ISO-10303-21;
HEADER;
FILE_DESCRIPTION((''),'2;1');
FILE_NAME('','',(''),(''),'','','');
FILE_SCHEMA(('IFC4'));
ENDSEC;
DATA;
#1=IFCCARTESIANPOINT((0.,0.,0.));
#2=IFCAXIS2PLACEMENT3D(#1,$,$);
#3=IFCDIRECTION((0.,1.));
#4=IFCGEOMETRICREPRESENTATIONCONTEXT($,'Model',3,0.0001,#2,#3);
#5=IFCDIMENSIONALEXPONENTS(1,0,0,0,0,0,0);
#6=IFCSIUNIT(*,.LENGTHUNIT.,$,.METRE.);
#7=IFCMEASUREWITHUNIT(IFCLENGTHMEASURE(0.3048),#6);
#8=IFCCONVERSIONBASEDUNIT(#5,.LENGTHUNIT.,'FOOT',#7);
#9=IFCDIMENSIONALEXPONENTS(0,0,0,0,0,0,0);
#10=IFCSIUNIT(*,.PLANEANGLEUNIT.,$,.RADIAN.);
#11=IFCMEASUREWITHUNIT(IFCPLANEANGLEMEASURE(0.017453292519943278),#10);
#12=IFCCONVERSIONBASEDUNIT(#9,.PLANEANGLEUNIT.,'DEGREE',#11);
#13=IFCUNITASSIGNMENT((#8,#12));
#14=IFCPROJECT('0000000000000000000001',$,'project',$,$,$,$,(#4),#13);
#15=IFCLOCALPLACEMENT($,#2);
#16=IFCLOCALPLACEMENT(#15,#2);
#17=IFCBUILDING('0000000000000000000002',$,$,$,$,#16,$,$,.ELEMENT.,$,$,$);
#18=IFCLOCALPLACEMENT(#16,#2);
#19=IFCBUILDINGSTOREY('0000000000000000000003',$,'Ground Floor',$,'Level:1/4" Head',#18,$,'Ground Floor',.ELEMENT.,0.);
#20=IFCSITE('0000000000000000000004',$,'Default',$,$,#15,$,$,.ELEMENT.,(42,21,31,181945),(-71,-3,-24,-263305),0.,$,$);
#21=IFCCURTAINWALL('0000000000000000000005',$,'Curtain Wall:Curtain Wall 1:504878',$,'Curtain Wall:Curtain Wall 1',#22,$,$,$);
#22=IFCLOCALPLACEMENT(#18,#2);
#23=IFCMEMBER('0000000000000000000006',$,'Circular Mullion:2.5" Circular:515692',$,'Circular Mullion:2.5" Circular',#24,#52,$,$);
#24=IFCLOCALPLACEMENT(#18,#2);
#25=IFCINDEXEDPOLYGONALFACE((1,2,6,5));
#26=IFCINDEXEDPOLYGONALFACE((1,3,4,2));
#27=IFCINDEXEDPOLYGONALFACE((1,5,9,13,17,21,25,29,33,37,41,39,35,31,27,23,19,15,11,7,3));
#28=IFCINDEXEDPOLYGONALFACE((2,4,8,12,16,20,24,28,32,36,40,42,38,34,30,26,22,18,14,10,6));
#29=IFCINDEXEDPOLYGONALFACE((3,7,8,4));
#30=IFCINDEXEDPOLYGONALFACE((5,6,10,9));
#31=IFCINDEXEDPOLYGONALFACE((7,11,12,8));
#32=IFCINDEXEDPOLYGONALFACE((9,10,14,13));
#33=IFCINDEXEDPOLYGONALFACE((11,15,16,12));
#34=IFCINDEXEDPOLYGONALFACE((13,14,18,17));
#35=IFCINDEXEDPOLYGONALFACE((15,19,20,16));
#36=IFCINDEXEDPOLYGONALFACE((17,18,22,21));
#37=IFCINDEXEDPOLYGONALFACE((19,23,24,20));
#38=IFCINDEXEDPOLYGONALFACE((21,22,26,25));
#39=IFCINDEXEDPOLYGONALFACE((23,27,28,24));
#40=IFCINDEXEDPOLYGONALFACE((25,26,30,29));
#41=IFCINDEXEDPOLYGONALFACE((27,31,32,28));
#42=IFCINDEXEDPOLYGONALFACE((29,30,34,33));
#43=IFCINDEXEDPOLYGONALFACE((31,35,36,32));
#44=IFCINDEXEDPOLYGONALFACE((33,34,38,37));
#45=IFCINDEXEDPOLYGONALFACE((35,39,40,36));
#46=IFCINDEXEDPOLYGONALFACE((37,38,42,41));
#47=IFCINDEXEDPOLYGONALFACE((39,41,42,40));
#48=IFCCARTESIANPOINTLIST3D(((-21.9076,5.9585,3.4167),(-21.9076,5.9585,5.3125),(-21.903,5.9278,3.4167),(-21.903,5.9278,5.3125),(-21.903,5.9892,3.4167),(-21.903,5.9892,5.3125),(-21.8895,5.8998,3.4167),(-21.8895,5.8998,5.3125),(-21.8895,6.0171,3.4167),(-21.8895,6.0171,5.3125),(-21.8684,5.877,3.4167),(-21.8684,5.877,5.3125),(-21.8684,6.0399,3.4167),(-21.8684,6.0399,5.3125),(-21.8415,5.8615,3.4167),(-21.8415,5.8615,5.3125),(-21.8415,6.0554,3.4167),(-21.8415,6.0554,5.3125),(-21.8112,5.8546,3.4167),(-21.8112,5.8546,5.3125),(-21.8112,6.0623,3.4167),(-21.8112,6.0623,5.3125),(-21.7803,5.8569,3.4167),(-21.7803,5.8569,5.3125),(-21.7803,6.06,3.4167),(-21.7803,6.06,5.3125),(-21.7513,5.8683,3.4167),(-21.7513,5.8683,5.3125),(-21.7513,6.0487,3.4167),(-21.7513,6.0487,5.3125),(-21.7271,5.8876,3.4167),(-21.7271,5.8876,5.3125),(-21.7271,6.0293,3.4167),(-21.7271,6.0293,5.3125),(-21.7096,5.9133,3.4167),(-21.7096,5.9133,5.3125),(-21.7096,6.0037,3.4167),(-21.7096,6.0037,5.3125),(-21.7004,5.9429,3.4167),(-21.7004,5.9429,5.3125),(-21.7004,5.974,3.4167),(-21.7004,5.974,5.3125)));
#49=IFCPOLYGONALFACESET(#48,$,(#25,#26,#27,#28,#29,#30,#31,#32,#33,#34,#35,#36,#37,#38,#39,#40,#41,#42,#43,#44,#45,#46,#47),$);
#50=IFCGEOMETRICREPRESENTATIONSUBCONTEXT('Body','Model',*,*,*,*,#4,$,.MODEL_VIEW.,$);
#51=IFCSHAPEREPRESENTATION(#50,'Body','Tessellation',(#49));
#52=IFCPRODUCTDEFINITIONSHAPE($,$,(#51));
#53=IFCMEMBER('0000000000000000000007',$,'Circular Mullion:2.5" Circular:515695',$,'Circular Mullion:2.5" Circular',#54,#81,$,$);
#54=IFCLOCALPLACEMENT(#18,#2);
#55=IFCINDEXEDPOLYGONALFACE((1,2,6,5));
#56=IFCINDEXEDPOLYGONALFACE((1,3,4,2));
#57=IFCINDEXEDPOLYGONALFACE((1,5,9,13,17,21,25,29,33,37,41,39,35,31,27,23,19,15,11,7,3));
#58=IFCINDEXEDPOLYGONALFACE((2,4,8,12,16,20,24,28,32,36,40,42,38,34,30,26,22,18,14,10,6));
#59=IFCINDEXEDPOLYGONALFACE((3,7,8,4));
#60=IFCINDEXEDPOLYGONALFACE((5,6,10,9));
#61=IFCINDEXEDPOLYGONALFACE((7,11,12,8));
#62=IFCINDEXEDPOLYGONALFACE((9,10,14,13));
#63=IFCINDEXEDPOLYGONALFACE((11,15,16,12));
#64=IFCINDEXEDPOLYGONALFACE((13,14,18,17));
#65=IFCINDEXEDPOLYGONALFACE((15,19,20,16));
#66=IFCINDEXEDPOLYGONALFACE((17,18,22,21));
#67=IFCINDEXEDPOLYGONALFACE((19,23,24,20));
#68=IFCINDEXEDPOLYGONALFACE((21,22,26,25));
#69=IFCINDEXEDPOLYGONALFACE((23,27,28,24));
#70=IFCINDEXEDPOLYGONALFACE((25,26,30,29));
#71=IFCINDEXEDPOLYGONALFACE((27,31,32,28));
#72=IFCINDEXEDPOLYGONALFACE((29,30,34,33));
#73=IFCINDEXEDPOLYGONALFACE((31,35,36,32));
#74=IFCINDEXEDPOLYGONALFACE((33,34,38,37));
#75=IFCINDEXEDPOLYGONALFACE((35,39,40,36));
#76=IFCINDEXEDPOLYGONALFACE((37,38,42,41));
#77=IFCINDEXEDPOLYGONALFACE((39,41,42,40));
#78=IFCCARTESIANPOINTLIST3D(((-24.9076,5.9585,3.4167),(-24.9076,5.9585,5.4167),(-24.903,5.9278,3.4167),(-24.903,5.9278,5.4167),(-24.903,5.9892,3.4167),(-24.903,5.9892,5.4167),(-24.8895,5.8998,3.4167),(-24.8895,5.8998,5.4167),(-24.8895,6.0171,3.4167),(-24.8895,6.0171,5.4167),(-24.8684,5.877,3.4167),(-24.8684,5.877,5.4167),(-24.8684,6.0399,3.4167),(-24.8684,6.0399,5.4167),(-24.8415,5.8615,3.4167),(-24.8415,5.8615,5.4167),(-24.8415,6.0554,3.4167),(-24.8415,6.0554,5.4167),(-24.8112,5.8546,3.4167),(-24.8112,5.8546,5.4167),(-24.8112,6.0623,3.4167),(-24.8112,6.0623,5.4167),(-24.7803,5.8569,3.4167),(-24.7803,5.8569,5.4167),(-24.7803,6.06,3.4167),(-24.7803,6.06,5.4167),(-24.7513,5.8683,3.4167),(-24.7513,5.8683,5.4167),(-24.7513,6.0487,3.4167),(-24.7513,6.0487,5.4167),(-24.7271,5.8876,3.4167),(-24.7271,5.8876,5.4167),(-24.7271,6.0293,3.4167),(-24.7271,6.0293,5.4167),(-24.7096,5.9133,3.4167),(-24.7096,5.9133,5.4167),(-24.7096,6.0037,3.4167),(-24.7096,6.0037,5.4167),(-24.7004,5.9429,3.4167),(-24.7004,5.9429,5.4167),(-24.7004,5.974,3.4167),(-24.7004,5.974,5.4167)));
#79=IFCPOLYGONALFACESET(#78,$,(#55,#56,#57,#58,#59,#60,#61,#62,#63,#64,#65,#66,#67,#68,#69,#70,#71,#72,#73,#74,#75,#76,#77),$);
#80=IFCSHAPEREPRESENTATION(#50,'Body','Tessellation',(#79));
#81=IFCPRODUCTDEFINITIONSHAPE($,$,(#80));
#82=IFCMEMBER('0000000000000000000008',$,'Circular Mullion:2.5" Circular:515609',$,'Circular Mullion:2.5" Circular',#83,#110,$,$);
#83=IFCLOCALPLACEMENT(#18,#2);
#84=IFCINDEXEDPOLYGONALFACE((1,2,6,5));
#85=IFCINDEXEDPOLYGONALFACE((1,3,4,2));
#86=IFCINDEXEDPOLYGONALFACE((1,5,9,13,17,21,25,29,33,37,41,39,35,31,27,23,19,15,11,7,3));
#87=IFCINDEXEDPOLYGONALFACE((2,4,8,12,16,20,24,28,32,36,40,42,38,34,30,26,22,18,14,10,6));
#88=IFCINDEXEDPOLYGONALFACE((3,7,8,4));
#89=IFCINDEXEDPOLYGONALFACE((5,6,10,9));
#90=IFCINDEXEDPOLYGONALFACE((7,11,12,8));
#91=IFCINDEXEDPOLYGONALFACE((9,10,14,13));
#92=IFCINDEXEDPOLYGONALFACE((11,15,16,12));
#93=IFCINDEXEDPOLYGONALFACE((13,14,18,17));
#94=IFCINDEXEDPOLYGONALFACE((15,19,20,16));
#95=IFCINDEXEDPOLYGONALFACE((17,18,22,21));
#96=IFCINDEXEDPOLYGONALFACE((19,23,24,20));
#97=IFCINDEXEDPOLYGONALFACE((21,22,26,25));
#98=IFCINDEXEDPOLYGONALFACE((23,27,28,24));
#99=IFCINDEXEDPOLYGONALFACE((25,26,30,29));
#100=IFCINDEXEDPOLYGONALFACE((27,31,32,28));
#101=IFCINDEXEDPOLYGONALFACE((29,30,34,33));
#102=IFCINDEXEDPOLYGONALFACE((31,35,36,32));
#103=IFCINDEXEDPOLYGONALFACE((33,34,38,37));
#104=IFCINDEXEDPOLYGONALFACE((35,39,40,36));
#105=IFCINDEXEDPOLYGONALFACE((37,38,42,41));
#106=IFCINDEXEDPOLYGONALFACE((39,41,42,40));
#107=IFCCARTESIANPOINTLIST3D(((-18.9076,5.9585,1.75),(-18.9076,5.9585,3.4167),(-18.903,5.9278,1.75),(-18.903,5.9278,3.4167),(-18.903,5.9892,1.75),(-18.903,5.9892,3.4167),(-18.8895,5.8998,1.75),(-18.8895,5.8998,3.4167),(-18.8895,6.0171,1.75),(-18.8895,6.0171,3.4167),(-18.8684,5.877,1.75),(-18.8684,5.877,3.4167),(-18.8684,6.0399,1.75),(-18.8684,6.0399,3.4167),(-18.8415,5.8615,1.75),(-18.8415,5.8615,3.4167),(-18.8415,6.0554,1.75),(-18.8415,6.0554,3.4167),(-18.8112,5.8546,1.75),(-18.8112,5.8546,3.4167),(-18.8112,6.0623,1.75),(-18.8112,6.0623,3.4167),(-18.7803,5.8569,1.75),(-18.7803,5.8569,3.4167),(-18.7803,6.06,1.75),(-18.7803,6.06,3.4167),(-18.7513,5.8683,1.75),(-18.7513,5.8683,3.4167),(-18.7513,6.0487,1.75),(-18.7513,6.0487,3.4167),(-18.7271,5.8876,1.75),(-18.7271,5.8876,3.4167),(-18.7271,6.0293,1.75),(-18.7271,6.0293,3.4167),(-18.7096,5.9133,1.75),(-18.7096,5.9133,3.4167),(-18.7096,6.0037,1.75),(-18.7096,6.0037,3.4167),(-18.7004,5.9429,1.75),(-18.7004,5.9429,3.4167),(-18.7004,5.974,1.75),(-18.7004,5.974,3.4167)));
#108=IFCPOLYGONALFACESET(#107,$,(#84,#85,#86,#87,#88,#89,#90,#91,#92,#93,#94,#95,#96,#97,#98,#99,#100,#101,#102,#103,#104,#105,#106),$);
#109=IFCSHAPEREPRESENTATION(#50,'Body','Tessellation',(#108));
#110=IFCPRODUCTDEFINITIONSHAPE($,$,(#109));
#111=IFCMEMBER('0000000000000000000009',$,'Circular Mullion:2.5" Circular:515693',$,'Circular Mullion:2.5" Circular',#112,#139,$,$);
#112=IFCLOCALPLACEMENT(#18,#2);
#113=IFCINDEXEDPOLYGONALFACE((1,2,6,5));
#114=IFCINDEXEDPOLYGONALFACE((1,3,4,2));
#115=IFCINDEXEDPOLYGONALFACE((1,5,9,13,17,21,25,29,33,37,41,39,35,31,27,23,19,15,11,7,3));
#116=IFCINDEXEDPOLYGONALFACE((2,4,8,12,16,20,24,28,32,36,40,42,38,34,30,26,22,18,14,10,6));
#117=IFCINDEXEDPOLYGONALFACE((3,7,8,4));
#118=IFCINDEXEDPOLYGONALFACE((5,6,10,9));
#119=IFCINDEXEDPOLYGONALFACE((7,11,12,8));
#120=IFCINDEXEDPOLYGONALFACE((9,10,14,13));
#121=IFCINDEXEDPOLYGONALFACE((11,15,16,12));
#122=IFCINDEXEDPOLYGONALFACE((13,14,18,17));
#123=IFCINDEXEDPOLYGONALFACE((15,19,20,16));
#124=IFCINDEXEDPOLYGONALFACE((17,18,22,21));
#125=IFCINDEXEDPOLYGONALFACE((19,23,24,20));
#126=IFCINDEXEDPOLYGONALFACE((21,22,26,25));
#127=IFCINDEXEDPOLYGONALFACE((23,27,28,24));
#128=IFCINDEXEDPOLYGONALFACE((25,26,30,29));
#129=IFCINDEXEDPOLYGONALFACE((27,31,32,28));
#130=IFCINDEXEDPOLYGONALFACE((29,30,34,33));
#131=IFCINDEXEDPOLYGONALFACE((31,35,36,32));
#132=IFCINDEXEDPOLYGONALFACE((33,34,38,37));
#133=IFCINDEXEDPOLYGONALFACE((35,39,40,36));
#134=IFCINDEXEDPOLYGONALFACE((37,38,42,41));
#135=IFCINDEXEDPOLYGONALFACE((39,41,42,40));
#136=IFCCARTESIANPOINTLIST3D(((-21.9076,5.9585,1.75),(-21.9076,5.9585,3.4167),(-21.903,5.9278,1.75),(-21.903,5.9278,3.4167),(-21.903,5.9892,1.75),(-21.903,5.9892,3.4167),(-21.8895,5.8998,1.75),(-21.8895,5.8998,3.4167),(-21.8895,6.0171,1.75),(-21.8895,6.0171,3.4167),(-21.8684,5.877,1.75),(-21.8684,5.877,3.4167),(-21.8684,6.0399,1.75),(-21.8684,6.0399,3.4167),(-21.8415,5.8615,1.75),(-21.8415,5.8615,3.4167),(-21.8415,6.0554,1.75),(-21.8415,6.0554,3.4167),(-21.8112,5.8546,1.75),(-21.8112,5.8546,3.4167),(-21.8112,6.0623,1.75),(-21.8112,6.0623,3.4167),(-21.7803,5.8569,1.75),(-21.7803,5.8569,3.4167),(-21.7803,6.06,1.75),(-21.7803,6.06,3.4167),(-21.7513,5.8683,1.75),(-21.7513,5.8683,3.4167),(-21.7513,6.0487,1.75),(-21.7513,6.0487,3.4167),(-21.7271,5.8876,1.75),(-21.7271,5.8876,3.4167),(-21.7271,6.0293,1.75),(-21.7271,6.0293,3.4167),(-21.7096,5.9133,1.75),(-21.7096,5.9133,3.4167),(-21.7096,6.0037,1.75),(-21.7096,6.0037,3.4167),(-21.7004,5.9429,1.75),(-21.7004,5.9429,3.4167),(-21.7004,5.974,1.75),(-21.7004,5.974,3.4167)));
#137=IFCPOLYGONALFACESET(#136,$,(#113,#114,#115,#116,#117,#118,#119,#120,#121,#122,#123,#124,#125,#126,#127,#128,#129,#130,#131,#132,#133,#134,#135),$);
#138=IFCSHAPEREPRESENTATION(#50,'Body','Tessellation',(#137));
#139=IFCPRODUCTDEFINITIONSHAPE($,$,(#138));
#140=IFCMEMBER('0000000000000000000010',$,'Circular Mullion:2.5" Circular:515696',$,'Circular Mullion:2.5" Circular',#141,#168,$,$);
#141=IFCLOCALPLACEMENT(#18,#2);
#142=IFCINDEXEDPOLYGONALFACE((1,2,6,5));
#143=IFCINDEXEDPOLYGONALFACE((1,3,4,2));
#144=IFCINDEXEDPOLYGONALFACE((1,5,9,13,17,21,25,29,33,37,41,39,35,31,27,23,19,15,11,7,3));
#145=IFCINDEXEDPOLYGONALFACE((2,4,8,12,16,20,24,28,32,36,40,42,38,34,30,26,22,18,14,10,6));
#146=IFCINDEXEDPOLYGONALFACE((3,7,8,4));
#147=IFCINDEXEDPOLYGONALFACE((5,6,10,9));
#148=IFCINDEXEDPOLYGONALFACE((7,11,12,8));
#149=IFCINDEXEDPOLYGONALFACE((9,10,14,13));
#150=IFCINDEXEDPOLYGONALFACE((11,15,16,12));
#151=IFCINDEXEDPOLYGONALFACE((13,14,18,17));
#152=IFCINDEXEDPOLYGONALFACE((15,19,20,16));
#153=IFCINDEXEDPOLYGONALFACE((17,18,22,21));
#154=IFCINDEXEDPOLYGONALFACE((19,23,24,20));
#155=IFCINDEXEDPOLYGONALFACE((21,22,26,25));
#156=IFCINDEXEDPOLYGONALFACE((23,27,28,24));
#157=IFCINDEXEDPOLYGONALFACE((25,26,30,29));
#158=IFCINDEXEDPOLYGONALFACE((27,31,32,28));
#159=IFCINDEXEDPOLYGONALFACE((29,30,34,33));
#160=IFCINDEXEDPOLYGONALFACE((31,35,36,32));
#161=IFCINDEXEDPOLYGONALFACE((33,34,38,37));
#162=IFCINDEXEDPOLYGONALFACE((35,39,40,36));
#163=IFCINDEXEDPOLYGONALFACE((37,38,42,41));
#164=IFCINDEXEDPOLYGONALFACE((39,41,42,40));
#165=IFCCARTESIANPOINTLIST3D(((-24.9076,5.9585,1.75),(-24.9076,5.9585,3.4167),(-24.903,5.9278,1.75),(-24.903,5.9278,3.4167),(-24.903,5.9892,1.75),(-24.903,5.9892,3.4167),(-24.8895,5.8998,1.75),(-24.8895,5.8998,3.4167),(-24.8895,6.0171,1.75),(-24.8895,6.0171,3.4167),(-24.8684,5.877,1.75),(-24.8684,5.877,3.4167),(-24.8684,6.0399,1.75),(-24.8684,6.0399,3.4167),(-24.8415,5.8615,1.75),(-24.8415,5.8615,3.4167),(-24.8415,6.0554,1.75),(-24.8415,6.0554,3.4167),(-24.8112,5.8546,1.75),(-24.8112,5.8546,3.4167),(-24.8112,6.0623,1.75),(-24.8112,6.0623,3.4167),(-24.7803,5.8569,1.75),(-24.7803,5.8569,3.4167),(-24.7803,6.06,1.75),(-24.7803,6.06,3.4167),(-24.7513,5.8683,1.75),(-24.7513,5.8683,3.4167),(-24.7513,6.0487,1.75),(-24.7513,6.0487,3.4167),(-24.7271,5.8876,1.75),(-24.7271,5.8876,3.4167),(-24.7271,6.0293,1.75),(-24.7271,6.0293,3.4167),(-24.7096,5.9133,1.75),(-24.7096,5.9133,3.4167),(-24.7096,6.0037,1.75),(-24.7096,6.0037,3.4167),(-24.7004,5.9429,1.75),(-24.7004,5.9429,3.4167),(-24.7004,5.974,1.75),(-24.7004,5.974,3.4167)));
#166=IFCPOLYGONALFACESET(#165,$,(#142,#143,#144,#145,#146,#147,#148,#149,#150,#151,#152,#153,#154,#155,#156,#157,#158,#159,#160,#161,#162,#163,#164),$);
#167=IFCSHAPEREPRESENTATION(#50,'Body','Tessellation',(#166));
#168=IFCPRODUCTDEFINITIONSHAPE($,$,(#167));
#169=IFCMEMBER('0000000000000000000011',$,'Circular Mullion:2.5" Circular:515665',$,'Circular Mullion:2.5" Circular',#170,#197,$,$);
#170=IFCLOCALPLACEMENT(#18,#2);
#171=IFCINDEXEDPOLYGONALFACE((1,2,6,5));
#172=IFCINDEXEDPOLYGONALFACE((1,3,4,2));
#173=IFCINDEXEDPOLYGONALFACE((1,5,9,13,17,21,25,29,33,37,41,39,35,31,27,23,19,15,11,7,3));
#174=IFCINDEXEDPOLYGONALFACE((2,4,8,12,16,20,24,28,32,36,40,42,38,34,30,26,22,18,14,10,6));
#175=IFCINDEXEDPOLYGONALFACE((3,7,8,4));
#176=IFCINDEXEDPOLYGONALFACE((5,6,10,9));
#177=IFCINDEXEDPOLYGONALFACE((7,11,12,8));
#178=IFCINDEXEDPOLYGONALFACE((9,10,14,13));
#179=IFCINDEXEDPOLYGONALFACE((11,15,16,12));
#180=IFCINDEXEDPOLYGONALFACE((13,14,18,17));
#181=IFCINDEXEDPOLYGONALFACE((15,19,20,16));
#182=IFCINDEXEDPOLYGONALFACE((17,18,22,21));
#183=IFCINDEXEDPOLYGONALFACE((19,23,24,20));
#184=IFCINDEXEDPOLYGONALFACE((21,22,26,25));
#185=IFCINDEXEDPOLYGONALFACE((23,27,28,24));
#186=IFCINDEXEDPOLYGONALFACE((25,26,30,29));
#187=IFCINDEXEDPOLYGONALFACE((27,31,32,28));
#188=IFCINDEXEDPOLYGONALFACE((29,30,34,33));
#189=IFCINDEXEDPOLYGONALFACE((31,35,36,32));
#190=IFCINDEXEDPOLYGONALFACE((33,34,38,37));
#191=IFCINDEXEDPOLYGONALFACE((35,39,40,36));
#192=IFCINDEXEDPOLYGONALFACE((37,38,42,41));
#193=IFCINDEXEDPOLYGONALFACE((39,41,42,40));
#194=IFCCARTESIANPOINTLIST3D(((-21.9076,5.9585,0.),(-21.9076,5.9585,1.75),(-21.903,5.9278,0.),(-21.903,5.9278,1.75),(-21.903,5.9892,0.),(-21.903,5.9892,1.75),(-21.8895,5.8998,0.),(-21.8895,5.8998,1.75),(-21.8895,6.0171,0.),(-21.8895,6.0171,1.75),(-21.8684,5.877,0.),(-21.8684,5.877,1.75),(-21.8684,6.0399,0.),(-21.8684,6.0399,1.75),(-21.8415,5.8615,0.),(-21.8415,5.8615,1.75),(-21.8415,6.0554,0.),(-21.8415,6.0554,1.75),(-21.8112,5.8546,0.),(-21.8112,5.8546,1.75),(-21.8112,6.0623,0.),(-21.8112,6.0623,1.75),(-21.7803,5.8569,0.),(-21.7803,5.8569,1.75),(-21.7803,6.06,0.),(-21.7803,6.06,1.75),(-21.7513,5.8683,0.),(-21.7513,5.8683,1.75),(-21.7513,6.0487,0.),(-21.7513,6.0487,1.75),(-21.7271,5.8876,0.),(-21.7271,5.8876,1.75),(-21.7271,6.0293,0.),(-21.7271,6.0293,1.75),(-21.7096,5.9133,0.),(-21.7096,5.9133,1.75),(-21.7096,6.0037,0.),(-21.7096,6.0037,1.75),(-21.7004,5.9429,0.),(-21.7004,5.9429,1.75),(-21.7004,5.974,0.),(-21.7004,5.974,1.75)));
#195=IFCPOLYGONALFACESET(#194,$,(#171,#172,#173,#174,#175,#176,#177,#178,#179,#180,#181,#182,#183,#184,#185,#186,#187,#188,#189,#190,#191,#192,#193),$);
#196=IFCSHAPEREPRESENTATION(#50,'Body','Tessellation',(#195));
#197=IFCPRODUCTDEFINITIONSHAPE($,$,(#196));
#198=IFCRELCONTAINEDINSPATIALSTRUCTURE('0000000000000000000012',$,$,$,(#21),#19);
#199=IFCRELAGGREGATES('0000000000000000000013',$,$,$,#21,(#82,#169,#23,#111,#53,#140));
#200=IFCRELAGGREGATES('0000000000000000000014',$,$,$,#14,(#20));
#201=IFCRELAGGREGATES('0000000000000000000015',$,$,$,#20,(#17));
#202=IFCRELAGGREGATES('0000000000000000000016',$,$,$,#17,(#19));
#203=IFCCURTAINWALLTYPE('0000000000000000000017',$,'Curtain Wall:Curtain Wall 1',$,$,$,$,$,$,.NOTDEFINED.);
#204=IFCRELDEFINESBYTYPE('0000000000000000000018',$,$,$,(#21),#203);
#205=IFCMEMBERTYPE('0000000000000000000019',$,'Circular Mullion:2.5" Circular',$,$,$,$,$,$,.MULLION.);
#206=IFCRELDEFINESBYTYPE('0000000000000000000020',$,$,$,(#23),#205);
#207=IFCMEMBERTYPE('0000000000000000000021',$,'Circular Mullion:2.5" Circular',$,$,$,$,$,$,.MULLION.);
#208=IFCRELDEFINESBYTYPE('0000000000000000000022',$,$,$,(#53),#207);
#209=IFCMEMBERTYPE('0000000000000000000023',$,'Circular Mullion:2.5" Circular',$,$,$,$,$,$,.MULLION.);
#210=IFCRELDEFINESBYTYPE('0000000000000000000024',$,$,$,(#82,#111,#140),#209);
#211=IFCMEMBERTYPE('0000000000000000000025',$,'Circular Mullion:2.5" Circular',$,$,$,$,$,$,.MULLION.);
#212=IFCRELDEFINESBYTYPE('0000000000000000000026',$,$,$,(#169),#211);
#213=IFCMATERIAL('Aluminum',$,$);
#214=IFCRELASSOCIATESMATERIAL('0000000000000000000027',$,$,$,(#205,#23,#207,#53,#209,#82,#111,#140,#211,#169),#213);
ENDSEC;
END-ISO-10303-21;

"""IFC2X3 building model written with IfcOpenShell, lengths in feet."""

from ifc_helpers import new_model, entity, si_unit, converted_unit, direction, frame, frame_2d, origin, place, context, subcontext, project, spatial, circle, extrude, source, transform, mapped, material, type_object, type_shapes, element, aggregate, save


model = new_model("IFC2X3")

# Units and contexts
model_context = context("Model", 3, precision=0.0001, world=origin(), true_north=direction((0.0, 1.0)))
body_context = subcontext(model_context, "Body", "Model", "MODEL_VIEW")
ifc_project = project(units=[converted_unit("LENGTHUNIT", "FOOT", entity("IfcLengthMeasure", 0.3048), si_unit("LENGTHUNIT", "METRE"), dimensions=[1, 0, 0, 0, 0, 0, 0]), converted_unit("PLANEANGLEUNIT", "DEGREE", entity("IfcPlaneAngleMeasure", 0.017453292519943278), si_unit("PLANEANGLEUNIT", "RADIAN"), dimensions=[0, 0, 0, 0, 0, 0, 0])], contexts=[model_context])

# Site, building, storey
site_placement = place(None, origin())
site = spatial("IfcSite", under=ifc_project, at=site_placement, Name="Default", CompositionType="ELEMENT", RefLatitude=(42, 21, 31, 181945), RefLongitude=(-71, -3, -24, -263305), RefElevation=0.0)
building_placement = place(site_placement, origin())
building = spatial("IfcBuilding", under=site, at=building_placement, CompositionType="ELEMENT")
storey_placement = place(building_placement, origin())
storey = spatial("IfcBuildingStorey", under=building, at=storey_placement, Name="Ground Floor", ObjectType="Level:1/4\" Head", LongName="Ground Floor", CompositionType="ELEMENT", Elevation=0.0)

# Curtain wall, members
curtain_wall_type = type_object("IfcCurtainWallType", Name="Curtain Wall:Curtain Wall 1", PredefinedType="NOTDEFINED")
curtain_wall_placement = place(storey_placement, origin())
curtain_wall = element("IfcCurtainWall", 1, at=curtain_wall_placement, inside=storey, type_object=curtain_wall_type, Name="Curtain Wall:Curtain Wall 1:504878", ObjectType="Curtain Wall:Curtain Wall 1")
ifc_material_1 = material(Name="Aluminum")
member_type_1 = type_object("IfcMemberType", Name="Circular Mullion:2.5\" Circular", PredefinedType="MULLION", material=ifc_material_1)
shared_shape_1 = source(origin(), body_context, "Body", "SweptSolid", [
    extrude(circle(Radius=0.1042, at=frame_2d((0.0, 0.0), x_axis=(1.0, 0.0))), frame((0.0, 0.0, -1.8958)), (0.0, 0.0, 1.0), 1.8958),
])
type_shapes(member_type_1, [shared_shape_1])
member_1_placement = place(curtain_wall_placement, frame((-21.8034, 5.9585, 3.4167), z_axis=(0.0, 0.0, -1.0), x_axis=(-1.0, 0.0, 0.0)))
member_1 = element("IfcMember", 2, at=member_1_placement, type_object=member_type_1, material=ifc_material_1, Name="Circular Mullion:2.5\" Circular:515692", ObjectType="Circular Mullion:2.5\" Circular", context=body_context, shape_type="MappedRepresentation", body=[
    mapped(shared_shape_1, transform((0.0, 0.0, 0.0), scale=1.0)),
])
member_type_2 = type_object("IfcMemberType", Name="Circular Mullion:2.5\" Circular", PredefinedType="MULLION", material=ifc_material_1)
shared_shape_2 = source(origin(), body_context, "Body", "SweptSolid", [
    extrude(circle(Radius=0.1042, at=frame_2d((0.0, 0.0), x_axis=(1.0, 0.0))), frame((0.0, 0.0, -2.0)), (0.0, 0.0, 1.0), 2.0),
])
type_shapes(member_type_2, [shared_shape_2])
member_2_placement = place(curtain_wall_placement, frame((-24.8034, 5.9585, 3.4167), z_axis=(0.0, 0.0, -1.0), x_axis=(-1.0, 0.0, 0.0)))
member_2 = element("IfcMember", 3, at=member_2_placement, type_object=member_type_2, material=ifc_material_1, Name="Circular Mullion:2.5\" Circular:515695", ObjectType="Circular Mullion:2.5\" Circular", context=body_context, shape_type="MappedRepresentation", body=[
    mapped(shared_shape_2, transform((0.0, 0.0, 0.0), scale=1.0)),
])
member_type_3 = type_object("IfcMemberType", Name="Circular Mullion:2.5\" Circular", PredefinedType="MULLION", material=ifc_material_1)
shared_shape_3 = source(origin(), body_context, "Body", "SweptSolid", [
    extrude(circle(Radius=0.1042, at=frame_2d((0.0, 0.0), x_axis=(1.0, 0.0))), frame((0.0, 0.0, -1.6667)), (0.0, 0.0, 1.0), 1.6667),
])
type_shapes(member_type_3, [shared_shape_3])
member_3_placement = place(curtain_wall_placement, frame((-18.8034, 5.9585, 1.75), z_axis=(0.0, 0.0, -1.0), x_axis=(-1.0, 0.0, 0.0)))
member_3 = element("IfcMember", 4, at=member_3_placement, type_object=member_type_3, material=ifc_material_1, Name="Circular Mullion:2.5\" Circular:515609", ObjectType="Circular Mullion:2.5\" Circular", context=body_context, shape_type="MappedRepresentation", body=[
    mapped(shared_shape_3, transform((0.0, 0.0, 0.0), scale=1.0)),
])
member_4_placement = place(curtain_wall_placement, frame((-21.8034, 5.9585, 1.75), z_axis=(0.0, 0.0, -1.0), x_axis=(-1.0, 0.0, 0.0)))
member_4 = element("IfcMember", 5, at=member_4_placement, type_object=member_type_3, material=ifc_material_1, Name="Circular Mullion:2.5\" Circular:515693", ObjectType="Circular Mullion:2.5\" Circular", context=body_context, shape_type="MappedRepresentation", body=[
    mapped(shared_shape_3, transform((0.0, 0.0, 0.0), scale=1.0)),
])
member_5_placement = place(curtain_wall_placement, frame((-24.8034, 5.9585, 1.75), z_axis=(0.0, 0.0, -1.0), x_axis=(-1.0, 0.0, 0.0)))
member_5 = element("IfcMember", 6, at=member_5_placement, type_object=member_type_3, material=ifc_material_1, Name="Circular Mullion:2.5\" Circular:515696", ObjectType="Circular Mullion:2.5\" Circular", context=body_context, shape_type="MappedRepresentation", body=[
    mapped(shared_shape_3, transform((0.0, 0.0, 0.0), scale=1.0)),
])
member_type_4 = type_object("IfcMemberType", Name="Circular Mullion:2.5\" Circular", PredefinedType="MULLION", material=ifc_material_1)
shared_shape_4 = source(origin(), body_context, "Body", "SweptSolid", [
    extrude(circle(Radius=0.1042, at=frame_2d((0.0, 0.0), x_axis=(1.0, 0.0))), frame((0.0, 0.0, -1.75)), (0.0, 0.0, 1.0), 1.75),
])
type_shapes(member_type_4, [shared_shape_4])
member_6_placement = place(curtain_wall_placement, frame((-21.8034, 5.9585, 0.0), z_axis=(0.0, 0.0, -1.0), x_axis=(-1.0, 0.0, 0.0)))
member_6 = element("IfcMember", 7, at=member_6_placement, type_object=member_type_4, material=ifc_material_1, Name="Circular Mullion:2.5\" Circular:515665", ObjectType="Circular Mullion:2.5\" Circular", context=body_context, shape_type="MappedRepresentation", body=[
    mapped(shared_shape_4, transform((0.0, 0.0, 0.0), scale=1.0)),
])
aggregate(curtain_wall, [member_3, member_6, member_1, member_4, member_2, member_5])

save(model, "model.ifc")
